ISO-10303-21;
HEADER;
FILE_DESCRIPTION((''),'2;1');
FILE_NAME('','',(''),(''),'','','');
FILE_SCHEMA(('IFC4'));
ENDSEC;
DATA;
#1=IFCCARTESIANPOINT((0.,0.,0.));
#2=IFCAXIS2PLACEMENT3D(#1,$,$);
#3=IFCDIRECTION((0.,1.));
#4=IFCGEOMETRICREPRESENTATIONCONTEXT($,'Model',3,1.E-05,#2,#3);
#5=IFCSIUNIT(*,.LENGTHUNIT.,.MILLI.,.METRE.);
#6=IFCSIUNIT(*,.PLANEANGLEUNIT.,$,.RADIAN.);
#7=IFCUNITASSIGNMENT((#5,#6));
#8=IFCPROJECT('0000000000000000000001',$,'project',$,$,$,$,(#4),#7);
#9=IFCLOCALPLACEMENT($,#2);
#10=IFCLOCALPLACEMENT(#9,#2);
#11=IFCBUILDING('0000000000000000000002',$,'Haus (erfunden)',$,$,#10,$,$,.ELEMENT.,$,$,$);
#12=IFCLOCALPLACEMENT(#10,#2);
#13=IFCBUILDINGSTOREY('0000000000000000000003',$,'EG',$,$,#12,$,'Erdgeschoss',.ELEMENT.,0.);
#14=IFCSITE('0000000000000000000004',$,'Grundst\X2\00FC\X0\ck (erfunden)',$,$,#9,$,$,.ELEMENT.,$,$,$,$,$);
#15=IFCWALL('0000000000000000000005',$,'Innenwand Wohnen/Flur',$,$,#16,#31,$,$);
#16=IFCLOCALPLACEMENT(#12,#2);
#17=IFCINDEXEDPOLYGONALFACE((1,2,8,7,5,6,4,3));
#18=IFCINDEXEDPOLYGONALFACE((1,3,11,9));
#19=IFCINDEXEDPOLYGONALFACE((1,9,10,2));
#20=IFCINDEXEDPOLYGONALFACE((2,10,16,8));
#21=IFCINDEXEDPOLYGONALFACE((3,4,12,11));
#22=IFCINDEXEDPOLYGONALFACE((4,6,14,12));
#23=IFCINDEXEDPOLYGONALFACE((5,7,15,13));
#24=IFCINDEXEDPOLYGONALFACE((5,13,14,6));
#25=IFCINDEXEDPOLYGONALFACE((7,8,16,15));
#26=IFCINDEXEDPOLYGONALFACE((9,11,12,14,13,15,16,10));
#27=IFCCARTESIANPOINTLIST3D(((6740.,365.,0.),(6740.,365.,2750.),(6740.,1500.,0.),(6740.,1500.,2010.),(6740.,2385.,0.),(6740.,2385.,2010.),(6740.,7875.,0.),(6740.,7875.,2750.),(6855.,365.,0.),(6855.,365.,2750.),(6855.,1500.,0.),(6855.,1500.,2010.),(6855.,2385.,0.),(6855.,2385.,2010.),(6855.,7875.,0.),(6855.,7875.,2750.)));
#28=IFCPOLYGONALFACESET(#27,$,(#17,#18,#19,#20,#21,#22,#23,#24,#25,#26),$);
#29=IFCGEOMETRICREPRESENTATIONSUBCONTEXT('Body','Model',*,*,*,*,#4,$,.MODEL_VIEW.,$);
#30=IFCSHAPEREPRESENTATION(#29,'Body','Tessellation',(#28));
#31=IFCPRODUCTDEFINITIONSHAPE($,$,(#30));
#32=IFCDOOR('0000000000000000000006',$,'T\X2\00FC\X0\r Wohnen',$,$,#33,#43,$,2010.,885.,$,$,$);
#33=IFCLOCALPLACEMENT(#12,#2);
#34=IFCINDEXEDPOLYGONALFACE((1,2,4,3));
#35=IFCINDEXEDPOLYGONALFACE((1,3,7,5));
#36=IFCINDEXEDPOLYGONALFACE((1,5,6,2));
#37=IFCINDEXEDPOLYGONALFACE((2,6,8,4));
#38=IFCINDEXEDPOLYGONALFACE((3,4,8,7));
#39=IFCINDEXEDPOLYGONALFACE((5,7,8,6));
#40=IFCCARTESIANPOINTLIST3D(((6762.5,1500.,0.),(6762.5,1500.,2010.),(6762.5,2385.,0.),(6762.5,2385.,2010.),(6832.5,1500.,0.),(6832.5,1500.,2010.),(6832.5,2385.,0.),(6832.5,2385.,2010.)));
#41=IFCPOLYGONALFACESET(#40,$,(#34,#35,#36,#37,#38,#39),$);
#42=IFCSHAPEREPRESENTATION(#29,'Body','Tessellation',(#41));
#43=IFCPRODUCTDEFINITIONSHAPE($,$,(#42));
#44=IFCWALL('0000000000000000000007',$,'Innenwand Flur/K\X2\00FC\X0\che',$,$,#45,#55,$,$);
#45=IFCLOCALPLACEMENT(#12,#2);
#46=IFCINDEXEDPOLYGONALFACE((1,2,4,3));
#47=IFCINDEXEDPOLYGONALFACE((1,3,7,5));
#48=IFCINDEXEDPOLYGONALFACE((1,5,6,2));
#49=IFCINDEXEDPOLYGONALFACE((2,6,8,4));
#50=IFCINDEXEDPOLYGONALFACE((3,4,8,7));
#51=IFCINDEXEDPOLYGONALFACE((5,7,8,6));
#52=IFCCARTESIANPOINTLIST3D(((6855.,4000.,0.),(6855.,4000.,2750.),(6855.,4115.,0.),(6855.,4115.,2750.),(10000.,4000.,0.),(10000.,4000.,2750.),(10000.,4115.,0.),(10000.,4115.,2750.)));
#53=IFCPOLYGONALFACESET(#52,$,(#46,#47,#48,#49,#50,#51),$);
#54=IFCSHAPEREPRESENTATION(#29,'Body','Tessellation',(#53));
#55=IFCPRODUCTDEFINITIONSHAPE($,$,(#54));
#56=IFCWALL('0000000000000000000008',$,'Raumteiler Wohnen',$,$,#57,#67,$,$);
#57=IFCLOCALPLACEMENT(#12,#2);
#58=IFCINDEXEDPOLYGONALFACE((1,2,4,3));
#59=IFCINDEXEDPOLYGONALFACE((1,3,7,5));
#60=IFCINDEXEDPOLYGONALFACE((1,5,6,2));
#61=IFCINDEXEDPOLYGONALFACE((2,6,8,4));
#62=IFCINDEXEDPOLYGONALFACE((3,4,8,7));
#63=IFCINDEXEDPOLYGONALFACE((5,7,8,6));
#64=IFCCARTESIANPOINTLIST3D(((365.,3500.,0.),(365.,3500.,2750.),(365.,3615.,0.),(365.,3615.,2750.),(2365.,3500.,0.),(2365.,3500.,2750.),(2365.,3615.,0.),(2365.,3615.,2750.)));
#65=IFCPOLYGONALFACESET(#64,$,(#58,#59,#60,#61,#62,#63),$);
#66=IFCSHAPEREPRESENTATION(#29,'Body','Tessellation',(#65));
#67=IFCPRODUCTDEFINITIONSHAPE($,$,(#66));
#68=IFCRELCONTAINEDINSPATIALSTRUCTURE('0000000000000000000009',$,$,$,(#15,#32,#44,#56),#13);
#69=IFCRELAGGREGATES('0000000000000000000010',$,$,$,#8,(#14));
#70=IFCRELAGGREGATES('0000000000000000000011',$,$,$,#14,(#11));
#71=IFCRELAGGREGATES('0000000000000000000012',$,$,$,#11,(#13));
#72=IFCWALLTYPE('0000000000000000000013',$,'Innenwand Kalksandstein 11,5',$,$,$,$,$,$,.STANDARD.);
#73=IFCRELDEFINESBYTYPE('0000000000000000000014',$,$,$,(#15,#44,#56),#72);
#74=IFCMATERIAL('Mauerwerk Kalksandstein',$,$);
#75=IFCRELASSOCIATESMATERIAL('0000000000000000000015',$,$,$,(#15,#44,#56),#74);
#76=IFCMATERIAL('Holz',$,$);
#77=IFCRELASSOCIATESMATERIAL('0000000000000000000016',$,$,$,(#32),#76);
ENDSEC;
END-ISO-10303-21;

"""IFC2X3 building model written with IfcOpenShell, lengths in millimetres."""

from ifc_helpers import new_model, si_unit, direction, frame, frame_2d, origin, place, context, subcontext, project, spatial, rectangle, extrude, material, type_object, element, fill, save


model = new_model("IFC2X3")

# Units and contexts
model_context = context("Model", 3, precision=1e-05, world=origin(), true_north=direction((0.0, 1.0)))
body_context = subcontext(model_context, "Body", "Model", "MODEL_VIEW")
ifc_project = project(units=[si_unit("LENGTHUNIT", "METRE", prefix="MILLI"), si_unit("PLANEANGLEUNIT", "RADIAN")], contexts=[model_context])

# Site, building, storey
site_placement = place(None, origin())
site = spatial("IfcSite", under=ifc_project, at=site_placement, Name="Grundstück (erfunden)", CompositionType="ELEMENT")
building_placement = place(site_placement, origin())
building = spatial("IfcBuilding", under=site, at=building_placement, Name="Haus (erfunden)", CompositionType="ELEMENT")
storey_placement = place(building_placement, origin())
storey = spatial("IfcBuildingStorey", under=building, at=storey_placement, Name="EG", LongName="Erdgeschoss", CompositionType="ELEMENT", Elevation=0.0)

# Shared definitions
ifc_material_1 = material(Name="Holz")

# Wall, opening, door
ifc_material_2 = material(Name="Mauerwerk Kalksandstein")
wall_type_1 = type_object("IfcWallType", Name="Innenwand Kalksandstein 11,5", PredefinedType="STANDARD")
wall_1_placement = place(storey_placement, frame((6740.0, 365.0, 0.0)))
wall_1 = element("IfcWall", 1, at=wall_1_placement, inside=storey, type_object=wall_type_1, material=ifc_material_2, Name="Innenwand Wohnen/Flur", context=body_context, shape_type="SweptSolid", body=[
    extrude(rectangle(XDim=115.0, YDim=7510.0, at=frame_2d((57.5, 3755.0))), origin(), (0.0, 0.0, 1.0), 2750.0),
])
opening_1_placement = place(wall_1_placement, frame((-50.0, 1135.0, 0.0)))
opening_1 = element("IfcOpeningElement", 2, at=opening_1_placement, cuts=wall_1, context=body_context, shape_type="SweptSolid", body=[
    extrude(rectangle(XDim=215.0, YDim=885.0, at=frame_2d((107.5, 442.5))), origin(), (0.0, 0.0, 1.0), 2010.0),
])
door_1_placement = place(opening_1_placement, frame((72.5, 0.0, 0.0)))
door_1 = element("IfcDoor", 3, at=door_1_placement, inside=storey, material=ifc_material_1, Name="Tür Wohnen", OverallHeight=2010.0, OverallWidth=885.0, context=body_context, shape_type="SweptSolid", body=[
    extrude(rectangle(XDim=70.0, YDim=885.0, at=frame_2d((35.0, 442.5))), origin(), (0.0, 0.0, 1.0), 2010.0),
])
fill(opening_1, door_1)

# Walls
wall_2_placement = place(storey_placement, frame((6855.0, 4000.0, 0.0)))
element("IfcWall", 4, at=wall_2_placement, inside=storey, type_object=wall_type_1, material=ifc_material_2, Name="Innenwand Flur/Küche", context=body_context, shape_type="SweptSolid", body=[
    extrude(rectangle(XDim=3145.0, YDim=115.0, at=frame_2d((1572.5, 57.5))), origin(), (0.0, 0.0, 1.0), 2750.0),
])
wall_3_placement = place(storey_placement, frame((365.0, 3500.0, 0.0)))
element("IfcWall", 5, at=wall_3_placement, inside=storey, type_object=wall_type_1, material=ifc_material_2, Name="Raumteiler Wohnen", context=body_context, shape_type="SweptSolid", body=[
    extrude(rectangle(XDim=2000.0, YDim=115.0, at=frame_2d((1000.0, 57.5))), origin(), (0.0, 0.0, 1.0), 2750.0),
])

save(model, "model.ifc")
